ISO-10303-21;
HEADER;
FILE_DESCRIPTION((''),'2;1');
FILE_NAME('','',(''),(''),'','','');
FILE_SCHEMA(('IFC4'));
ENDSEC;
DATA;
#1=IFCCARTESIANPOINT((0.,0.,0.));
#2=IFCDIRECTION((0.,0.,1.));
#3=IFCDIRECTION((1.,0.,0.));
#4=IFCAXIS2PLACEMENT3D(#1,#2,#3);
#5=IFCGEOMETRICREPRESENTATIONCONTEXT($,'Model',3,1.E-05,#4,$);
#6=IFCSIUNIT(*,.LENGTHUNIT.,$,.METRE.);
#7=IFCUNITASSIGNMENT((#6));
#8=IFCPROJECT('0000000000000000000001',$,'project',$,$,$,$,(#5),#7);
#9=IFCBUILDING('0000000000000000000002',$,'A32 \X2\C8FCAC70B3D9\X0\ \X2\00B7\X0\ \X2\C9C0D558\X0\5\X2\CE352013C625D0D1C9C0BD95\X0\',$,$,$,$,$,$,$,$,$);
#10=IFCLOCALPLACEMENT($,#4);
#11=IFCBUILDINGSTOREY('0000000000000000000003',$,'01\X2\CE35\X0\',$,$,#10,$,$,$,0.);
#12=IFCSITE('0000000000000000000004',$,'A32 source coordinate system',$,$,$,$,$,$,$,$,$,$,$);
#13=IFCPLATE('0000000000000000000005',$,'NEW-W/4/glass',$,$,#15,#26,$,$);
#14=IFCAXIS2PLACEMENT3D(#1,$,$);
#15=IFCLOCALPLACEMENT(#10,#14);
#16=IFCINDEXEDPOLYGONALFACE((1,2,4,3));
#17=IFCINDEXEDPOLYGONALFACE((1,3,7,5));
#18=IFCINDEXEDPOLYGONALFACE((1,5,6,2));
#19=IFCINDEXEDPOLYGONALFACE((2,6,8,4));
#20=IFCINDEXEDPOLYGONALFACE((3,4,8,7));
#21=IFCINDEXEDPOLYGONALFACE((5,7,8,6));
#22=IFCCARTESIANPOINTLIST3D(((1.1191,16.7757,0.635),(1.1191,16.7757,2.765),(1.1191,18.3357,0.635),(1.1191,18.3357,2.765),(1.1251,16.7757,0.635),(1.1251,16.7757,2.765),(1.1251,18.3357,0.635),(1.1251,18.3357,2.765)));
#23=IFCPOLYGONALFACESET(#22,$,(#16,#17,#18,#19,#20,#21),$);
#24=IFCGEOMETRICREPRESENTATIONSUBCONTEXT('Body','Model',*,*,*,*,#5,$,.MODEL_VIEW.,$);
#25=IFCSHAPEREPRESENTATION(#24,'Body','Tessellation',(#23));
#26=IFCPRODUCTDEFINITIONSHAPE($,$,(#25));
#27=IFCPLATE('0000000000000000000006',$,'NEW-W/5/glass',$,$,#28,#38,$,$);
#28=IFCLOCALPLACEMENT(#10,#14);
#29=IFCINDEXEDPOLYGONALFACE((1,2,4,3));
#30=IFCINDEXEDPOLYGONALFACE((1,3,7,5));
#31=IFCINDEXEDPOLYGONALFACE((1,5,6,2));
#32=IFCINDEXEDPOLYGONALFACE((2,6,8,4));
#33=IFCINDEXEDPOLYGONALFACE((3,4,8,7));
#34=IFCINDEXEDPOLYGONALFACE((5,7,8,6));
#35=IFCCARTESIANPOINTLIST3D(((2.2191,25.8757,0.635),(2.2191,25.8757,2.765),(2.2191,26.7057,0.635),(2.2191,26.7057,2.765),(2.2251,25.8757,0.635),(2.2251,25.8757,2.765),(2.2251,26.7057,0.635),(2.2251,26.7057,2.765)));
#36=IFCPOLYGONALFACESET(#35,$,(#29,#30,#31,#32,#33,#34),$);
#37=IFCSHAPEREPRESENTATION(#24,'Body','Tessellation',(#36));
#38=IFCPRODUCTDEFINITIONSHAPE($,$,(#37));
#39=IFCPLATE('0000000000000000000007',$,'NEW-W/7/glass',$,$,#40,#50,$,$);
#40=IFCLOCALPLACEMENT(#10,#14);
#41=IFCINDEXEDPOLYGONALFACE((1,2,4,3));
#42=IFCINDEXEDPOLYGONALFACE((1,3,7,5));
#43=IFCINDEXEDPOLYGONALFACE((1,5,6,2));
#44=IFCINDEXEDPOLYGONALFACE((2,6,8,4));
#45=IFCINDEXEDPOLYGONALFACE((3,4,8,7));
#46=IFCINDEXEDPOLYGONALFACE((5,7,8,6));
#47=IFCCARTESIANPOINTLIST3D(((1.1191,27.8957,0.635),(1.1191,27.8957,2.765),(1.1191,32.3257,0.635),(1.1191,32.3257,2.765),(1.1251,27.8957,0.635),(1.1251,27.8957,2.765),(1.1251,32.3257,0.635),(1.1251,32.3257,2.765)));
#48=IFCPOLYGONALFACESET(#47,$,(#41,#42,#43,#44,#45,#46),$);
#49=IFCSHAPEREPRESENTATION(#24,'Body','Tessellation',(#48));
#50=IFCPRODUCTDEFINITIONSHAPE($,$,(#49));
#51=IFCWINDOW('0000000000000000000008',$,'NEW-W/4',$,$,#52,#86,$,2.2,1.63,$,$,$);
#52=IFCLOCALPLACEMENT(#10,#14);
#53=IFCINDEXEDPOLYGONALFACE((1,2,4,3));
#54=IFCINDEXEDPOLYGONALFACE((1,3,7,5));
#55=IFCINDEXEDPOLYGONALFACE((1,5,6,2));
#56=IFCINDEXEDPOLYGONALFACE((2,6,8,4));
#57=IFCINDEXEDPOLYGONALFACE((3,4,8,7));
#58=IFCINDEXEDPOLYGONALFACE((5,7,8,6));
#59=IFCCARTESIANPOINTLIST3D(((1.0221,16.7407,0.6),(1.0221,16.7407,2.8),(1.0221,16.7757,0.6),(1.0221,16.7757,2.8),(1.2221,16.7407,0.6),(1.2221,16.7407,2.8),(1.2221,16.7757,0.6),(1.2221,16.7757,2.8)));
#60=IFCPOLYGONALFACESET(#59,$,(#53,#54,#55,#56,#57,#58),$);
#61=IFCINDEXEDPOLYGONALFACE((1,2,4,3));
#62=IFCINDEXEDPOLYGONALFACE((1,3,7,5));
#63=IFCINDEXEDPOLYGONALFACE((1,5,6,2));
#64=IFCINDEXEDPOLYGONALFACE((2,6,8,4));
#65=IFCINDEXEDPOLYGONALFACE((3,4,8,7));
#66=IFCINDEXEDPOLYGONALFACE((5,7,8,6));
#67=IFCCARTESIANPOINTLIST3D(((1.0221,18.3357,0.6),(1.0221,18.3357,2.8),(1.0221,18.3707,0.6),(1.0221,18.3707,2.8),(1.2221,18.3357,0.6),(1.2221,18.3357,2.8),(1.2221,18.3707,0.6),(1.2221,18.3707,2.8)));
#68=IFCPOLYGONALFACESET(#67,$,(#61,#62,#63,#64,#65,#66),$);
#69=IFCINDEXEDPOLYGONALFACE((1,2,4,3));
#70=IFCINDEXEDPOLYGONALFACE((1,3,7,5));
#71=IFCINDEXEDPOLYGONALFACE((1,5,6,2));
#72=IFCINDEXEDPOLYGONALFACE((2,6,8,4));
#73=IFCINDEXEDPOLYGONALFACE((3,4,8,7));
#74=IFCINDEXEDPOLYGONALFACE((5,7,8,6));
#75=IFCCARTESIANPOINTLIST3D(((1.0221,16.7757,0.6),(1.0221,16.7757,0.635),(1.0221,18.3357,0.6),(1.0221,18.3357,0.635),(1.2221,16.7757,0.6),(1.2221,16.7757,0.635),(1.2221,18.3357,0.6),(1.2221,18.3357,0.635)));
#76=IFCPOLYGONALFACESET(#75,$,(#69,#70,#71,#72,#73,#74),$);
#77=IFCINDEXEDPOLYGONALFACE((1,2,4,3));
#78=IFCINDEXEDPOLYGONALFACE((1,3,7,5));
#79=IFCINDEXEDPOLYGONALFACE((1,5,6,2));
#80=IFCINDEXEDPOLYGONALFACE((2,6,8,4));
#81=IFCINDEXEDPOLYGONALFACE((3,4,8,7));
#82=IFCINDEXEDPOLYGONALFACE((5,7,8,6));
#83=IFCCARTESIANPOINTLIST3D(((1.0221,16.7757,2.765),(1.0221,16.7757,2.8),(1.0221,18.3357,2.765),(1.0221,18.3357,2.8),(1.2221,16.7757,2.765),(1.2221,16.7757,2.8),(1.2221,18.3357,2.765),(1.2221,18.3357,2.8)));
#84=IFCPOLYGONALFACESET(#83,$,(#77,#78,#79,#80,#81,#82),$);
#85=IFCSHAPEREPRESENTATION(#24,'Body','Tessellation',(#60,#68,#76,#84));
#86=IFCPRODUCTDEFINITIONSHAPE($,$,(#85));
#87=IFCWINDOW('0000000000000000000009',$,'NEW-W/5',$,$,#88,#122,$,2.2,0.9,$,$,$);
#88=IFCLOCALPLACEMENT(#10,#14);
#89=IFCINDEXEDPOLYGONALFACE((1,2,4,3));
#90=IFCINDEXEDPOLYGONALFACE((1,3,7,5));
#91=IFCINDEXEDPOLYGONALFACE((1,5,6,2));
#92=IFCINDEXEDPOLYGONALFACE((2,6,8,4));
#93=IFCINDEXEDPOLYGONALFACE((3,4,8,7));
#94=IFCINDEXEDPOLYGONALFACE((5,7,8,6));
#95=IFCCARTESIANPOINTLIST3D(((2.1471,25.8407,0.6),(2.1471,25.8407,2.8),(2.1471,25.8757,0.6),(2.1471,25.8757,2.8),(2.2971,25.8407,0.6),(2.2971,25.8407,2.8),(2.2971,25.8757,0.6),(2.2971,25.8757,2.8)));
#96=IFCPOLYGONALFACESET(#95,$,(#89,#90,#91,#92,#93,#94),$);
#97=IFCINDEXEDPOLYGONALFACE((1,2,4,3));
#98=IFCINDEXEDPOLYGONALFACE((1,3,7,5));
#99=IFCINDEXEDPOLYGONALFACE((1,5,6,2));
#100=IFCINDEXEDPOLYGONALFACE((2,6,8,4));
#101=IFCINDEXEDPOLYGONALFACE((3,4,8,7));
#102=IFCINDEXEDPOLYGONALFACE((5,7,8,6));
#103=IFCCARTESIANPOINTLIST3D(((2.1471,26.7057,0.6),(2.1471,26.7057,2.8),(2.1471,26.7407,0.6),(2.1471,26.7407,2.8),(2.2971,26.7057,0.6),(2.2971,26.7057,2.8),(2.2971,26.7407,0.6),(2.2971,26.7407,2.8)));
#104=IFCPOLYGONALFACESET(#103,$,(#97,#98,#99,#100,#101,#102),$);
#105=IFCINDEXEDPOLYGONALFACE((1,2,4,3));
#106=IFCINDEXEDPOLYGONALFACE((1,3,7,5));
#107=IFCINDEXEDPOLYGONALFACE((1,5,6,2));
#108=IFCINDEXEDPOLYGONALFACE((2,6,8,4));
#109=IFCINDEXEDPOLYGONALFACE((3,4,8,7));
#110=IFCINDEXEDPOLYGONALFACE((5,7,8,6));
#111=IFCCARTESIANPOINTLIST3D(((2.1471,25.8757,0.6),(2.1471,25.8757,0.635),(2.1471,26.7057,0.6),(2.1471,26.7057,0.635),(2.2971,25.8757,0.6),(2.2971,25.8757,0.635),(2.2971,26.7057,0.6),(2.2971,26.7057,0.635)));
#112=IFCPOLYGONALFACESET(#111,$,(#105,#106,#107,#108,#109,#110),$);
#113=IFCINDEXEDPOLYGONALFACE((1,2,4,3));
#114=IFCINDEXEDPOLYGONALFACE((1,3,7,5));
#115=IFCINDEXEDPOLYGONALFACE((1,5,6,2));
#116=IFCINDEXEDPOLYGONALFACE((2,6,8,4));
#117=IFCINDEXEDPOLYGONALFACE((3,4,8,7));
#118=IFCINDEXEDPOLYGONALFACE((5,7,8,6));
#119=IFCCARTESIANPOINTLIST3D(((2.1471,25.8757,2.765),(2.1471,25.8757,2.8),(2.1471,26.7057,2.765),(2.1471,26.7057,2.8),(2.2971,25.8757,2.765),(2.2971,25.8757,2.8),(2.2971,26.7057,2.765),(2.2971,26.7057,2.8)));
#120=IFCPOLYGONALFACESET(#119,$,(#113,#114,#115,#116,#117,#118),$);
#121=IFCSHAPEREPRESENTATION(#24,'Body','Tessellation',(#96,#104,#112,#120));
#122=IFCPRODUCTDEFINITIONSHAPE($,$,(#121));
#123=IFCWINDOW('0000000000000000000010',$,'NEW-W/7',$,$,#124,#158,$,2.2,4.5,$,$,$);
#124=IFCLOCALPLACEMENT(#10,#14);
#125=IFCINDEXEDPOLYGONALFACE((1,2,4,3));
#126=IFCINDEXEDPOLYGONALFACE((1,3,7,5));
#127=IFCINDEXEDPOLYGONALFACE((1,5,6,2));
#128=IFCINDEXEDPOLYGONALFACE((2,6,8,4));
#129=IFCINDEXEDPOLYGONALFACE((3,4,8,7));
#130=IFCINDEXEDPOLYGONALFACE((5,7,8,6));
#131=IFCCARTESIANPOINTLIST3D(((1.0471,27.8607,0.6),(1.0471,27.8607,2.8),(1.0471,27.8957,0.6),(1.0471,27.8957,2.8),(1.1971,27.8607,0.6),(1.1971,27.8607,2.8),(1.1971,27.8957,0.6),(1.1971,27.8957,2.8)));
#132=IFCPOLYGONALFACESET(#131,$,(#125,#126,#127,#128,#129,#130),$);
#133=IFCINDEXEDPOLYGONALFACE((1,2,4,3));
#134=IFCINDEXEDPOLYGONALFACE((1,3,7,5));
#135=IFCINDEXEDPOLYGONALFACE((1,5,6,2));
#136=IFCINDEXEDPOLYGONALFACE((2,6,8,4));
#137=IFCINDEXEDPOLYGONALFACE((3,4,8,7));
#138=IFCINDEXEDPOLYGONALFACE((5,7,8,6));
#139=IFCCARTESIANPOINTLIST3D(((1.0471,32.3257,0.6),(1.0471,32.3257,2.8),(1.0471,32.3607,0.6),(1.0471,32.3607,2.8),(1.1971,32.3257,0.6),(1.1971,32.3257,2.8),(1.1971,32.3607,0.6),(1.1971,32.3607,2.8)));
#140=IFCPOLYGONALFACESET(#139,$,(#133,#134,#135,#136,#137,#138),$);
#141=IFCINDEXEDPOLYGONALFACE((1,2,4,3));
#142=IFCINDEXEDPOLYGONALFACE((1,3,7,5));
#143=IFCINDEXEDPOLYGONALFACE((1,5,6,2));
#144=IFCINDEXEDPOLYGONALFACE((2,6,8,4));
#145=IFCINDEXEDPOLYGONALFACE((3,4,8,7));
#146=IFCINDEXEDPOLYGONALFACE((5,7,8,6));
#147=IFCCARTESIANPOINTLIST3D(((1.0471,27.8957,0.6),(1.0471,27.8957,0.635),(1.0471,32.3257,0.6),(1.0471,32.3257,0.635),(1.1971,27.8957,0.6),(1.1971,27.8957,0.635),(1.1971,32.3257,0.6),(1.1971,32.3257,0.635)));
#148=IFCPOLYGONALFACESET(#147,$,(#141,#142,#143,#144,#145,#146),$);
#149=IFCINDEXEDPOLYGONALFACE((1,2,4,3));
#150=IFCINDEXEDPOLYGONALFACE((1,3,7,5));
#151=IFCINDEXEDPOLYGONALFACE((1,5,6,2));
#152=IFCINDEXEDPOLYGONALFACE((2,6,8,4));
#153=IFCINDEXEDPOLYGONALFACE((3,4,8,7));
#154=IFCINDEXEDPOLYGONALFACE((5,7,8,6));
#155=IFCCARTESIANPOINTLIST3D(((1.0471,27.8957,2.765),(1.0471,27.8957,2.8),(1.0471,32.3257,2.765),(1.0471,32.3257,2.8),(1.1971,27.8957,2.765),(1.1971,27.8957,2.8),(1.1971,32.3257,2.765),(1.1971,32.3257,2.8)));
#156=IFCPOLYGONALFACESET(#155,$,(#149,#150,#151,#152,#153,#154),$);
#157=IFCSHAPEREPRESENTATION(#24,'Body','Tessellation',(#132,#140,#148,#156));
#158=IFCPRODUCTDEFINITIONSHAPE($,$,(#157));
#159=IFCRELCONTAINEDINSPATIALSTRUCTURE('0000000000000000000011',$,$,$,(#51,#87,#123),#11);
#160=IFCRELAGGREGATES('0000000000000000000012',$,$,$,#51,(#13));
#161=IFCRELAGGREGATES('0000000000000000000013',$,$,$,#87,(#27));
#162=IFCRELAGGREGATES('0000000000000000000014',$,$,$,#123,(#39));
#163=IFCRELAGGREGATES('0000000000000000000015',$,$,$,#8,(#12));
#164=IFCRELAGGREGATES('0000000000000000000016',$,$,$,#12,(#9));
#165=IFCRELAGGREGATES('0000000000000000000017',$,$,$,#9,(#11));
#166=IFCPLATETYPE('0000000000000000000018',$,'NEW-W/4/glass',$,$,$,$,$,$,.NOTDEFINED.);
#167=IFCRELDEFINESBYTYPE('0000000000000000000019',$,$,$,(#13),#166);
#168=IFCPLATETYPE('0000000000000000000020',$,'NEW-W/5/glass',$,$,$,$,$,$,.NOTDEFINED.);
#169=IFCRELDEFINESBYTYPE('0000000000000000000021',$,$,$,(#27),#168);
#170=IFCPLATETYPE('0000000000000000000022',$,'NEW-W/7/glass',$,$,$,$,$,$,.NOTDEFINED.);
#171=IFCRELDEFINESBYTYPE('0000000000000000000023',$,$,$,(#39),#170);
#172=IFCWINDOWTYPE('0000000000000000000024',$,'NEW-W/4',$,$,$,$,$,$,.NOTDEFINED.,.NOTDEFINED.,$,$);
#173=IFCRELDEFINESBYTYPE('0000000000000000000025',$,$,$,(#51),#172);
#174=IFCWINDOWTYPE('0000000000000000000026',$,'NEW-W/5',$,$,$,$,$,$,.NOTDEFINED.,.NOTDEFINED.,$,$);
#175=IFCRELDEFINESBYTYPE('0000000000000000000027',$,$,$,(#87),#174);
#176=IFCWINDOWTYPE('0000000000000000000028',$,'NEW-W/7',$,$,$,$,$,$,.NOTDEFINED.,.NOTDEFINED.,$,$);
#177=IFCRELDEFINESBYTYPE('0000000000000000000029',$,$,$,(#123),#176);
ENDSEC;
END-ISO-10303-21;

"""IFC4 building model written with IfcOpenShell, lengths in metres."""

from ifc_helpers import new_model, si_unit, frame, origin, origin_with_axes, place, context, subcontext, project, spatial, polyline, outline, extrude, source, transform, mapped, type_object, type_shapes, element, aggregate, save


model = new_model("IFC4")

# Units and contexts
model_context = context("Model", 3, precision=1e-05, world=origin_with_axes())
body_context = subcontext(model_context, "Body", "Model", "MODEL_VIEW")
ifc_project = project(units=[si_unit("LENGTHUNIT", "METRE")], contexts=[model_context])

# Plates
storey_placement = place(None, origin_with_axes())
plate_type_1 = type_object("IfcPlateType", Name="NEW-W/4/glass", PredefinedType="NOTDEFINED")
shared_shape_1 = source(origin(), body_context, "Body", "SweptSolid", [
    extrude(outline(polyline([(1.1251, 16.7757), (1.1191, 16.7757), (1.1191, 18.3357), (1.1251, 18.3357), (1.1251, 16.7757)])), frame((0.0, 0.0, 0.635)), (0.0, 0.0, 1.0), 2.13),
])
type_shapes(plate_type_1, [shared_shape_1])
window_1_placement = place(storey_placement, origin_with_axes())
plate_1_placement = place(window_1_placement, origin_with_axes())
plate_1 = element("IfcPlate", 1, at=plate_1_placement, type_object=plate_type_1, Name="NEW-W/4/glass", context=body_context, shape_type="MappedRepresentation", body=[
    mapped(shared_shape_1, transform((0.0, 0.0, 0.0), scale=1.0)),
])
plate_type_2 = type_object("IfcPlateType", Name="NEW-W/5/glass", PredefinedType="NOTDEFINED")
shared_shape_2 = source(origin(), body_context, "Body", "SweptSolid", [
    extrude(outline(polyline([(2.2251, 25.8757), (2.2191, 25.8757), (2.2191, 26.7057), (2.2251, 26.7057), (2.2251, 25.8757)])), frame((0.0, 0.0, 0.635)), (0.0, 0.0, 1.0), 2.13),
])
type_shapes(plate_type_2, [shared_shape_2])
window_2_placement = place(storey_placement, origin_with_axes())
plate_2_placement = place(window_2_placement, origin_with_axes())
plate_2 = element("IfcPlate", 2, at=plate_2_placement, type_object=plate_type_2, Name="NEW-W/5/glass", context=body_context, shape_type="MappedRepresentation", body=[
    mapped(shared_shape_2, transform((0.0, 0.0, 0.0), scale=1.0)),
])
plate_type_3 = type_object("IfcPlateType", Name="NEW-W/7/glass", PredefinedType="NOTDEFINED")
shared_shape_3 = source(origin(), body_context, "Body", "SweptSolid", [
    extrude(outline(polyline([(1.1251, 27.8957), (1.1191, 27.8957), (1.1191, 32.3257), (1.1251, 32.3257), (1.1251, 27.8957)])), frame((0.0, 0.0, 0.635)), (0.0, 0.0, 1.0), 2.13),
])
type_shapes(plate_type_3, [shared_shape_3])
window_3_placement = place(storey_placement, origin_with_axes())
plate_3_placement = place(window_3_placement, origin_with_axes())
plate_3 = element("IfcPlate", 3, at=plate_3_placement, type_object=plate_type_3, Name="NEW-W/7/glass", context=body_context, shape_type="MappedRepresentation", body=[
    mapped(shared_shape_3, transform((0.0, 0.0, 0.0), scale=1.0)),
])

# Site, building, storey
site = spatial("IfcSite", under=ifc_project, Name="A32 source coordinate system")
building = spatial("IfcBuilding", under=site, Name="A32 주거동 · 지하5층–옥탑지붕")
storey = spatial("IfcBuildingStorey", under=building, at=storey_placement, Name="01층", Elevation=0.0)

# Windows
window_type_1 = type_object("IfcWindowType", Name="NEW-W/4", PartitioningType="NOTDEFINED", PredefinedType="NOTDEFINED")
shared_shape_4 = source(origin(), body_context, "Body", "SweptSolid", [
    extrude(outline(polyline([(1.0221, 16.7407), (1.0221, 16.7757), (1.2221, 16.7757), (1.2221, 16.7407), (1.0221, 16.7407)])), frame((0.0, 0.0, 0.6)), (0.0, 0.0, 1.0), 2.2),
    extrude(outline(polyline([(1.0221, 18.3357), (1.0221, 18.3707), (1.2221, 18.3707), (1.2221, 18.3357), (1.0221, 18.3357)])), frame((0.0, 0.0, 0.6)), (0.0, 0.0, 1.0), 2.2),
    extrude(outline(polyline([(1.2221, 16.7757), (1.2221, 18.3357), (1.0221, 18.3357), (1.0221, 16.7757), (1.2221, 16.7757)])), frame((0.0, 0.0, 0.6)), (0.0, 0.0, 1.0), 0.035),
    extrude(outline(polyline([(1.2221, 16.7757), (1.2221, 18.3357), (1.0221, 18.3357), (1.0221, 16.7757), (1.2221, 16.7757)])), frame((0.0, 0.0, 2.765)), (0.0, 0.0, 1.0), 0.035),
])
type_shapes(window_type_1, [shared_shape_4])
window_1 = element("IfcWindow", 4, at=window_1_placement, inside=storey, type_object=window_type_1, Name="NEW-W/4", OverallHeight=2.2, OverallWidth=1.63, context=body_context, shape_type="MappedRepresentation", body=[
    mapped(shared_shape_4, transform((0.0, 0.0, 0.0), scale=1.0)),
])
aggregate(window_1, [plate_1])
window_type_2 = type_object("IfcWindowType", Name="NEW-W/5", PartitioningType="NOTDEFINED", PredefinedType="NOTDEFINED")
shared_shape_5 = source(origin(), body_context, "Body", "SweptSolid", [
    extrude(outline(polyline([(2.1471, 25.8407), (2.1471, 25.8757), (2.2971, 25.8757), (2.2971, 25.8407), (2.1471, 25.8407)])), frame((0.0, 0.0, 0.6)), (0.0, 0.0, 1.0), 2.2),
    extrude(outline(polyline([(2.1471, 26.7057), (2.1471, 26.7407), (2.2971, 26.7407), (2.2971, 26.7057), (2.1471, 26.7057)])), frame((0.0, 0.0, 0.6)), (0.0, 0.0, 1.0), 2.2),
    extrude(outline(polyline([(2.2971, 25.8757), (2.2971, 26.7057), (2.1471, 26.7057), (2.1471, 25.8757), (2.2971, 25.8757)])), frame((0.0, 0.0, 0.6)), (0.0, 0.0, 1.0), 0.035),
    extrude(outline(polyline([(2.2971, 25.8757), (2.2971, 26.7057), (2.1471, 26.7057), (2.1471, 25.8757), (2.2971, 25.8757)])), frame((0.0, 0.0, 2.765)), (0.0, 0.0, 1.0), 0.035),
])
type_shapes(window_type_2, [shared_shape_5])
window_2 = element("IfcWindow", 5, at=window_2_placement, inside=storey, type_object=window_type_2, Name="NEW-W/5", OverallHeight=2.2, OverallWidth=0.9, context=body_context, shape_type="MappedRepresentation", body=[
    mapped(shared_shape_5, transform((0.0, 0.0, 0.0), scale=1.0)),
])
aggregate(window_2, [plate_2])
window_type_3 = type_object("IfcWindowType", Name="NEW-W/7", PartitioningType="NOTDEFINED", PredefinedType="NOTDEFINED")
shared_shape_6 = source(origin(), body_context, "Body", "SweptSolid", [
    extrude(outline(polyline([(1.0471, 27.8607), (1.0471, 27.8957), (1.1971, 27.8957), (1.1971, 27.8607), (1.0471, 27.8607)])), frame((0.0, 0.0, 0.6)), (0.0, 0.0, 1.0), 2.2),
    extrude(outline(polyline([(1.0471, 32.3257), (1.0471, 32.3607), (1.1971, 32.3607), (1.1971, 32.3257), (1.0471, 32.3257)])), frame((0.0, 0.0, 0.6)), (0.0, 0.0, 1.0), 2.2),
    extrude(outline(polyline([(1.1971, 27.8957), (1.1971, 32.3257), (1.0471, 32.3257), (1.0471, 27.8957), (1.1971, 27.8957)])), frame((0.0, 0.0, 0.6)), (0.0, 0.0, 1.0), 0.035),
    extrude(outline(polyline([(1.1971, 27.8957), (1.1971, 32.3257), (1.0471, 32.3257), (1.0471, 27.8957), (1.1971, 27.8957)])), frame((0.0, 0.0, 2.765)), (0.0, 0.0, 1.0), 0.035),
])
type_shapes(window_type_3, [shared_shape_6])
window_3 = element("IfcWindow", 6, at=window_3_placement, inside=storey, type_object=window_type_3, Name="NEW-W/7", OverallHeight=2.2, OverallWidth=4.5, context=body_context, shape_type="MappedRepresentation", body=[
    mapped(shared_shape_6, transform((0.0, 0.0, 0.0), scale=1.0)),
])
aggregate(window_3, [plate_3])

save(model, "model.ifc")
